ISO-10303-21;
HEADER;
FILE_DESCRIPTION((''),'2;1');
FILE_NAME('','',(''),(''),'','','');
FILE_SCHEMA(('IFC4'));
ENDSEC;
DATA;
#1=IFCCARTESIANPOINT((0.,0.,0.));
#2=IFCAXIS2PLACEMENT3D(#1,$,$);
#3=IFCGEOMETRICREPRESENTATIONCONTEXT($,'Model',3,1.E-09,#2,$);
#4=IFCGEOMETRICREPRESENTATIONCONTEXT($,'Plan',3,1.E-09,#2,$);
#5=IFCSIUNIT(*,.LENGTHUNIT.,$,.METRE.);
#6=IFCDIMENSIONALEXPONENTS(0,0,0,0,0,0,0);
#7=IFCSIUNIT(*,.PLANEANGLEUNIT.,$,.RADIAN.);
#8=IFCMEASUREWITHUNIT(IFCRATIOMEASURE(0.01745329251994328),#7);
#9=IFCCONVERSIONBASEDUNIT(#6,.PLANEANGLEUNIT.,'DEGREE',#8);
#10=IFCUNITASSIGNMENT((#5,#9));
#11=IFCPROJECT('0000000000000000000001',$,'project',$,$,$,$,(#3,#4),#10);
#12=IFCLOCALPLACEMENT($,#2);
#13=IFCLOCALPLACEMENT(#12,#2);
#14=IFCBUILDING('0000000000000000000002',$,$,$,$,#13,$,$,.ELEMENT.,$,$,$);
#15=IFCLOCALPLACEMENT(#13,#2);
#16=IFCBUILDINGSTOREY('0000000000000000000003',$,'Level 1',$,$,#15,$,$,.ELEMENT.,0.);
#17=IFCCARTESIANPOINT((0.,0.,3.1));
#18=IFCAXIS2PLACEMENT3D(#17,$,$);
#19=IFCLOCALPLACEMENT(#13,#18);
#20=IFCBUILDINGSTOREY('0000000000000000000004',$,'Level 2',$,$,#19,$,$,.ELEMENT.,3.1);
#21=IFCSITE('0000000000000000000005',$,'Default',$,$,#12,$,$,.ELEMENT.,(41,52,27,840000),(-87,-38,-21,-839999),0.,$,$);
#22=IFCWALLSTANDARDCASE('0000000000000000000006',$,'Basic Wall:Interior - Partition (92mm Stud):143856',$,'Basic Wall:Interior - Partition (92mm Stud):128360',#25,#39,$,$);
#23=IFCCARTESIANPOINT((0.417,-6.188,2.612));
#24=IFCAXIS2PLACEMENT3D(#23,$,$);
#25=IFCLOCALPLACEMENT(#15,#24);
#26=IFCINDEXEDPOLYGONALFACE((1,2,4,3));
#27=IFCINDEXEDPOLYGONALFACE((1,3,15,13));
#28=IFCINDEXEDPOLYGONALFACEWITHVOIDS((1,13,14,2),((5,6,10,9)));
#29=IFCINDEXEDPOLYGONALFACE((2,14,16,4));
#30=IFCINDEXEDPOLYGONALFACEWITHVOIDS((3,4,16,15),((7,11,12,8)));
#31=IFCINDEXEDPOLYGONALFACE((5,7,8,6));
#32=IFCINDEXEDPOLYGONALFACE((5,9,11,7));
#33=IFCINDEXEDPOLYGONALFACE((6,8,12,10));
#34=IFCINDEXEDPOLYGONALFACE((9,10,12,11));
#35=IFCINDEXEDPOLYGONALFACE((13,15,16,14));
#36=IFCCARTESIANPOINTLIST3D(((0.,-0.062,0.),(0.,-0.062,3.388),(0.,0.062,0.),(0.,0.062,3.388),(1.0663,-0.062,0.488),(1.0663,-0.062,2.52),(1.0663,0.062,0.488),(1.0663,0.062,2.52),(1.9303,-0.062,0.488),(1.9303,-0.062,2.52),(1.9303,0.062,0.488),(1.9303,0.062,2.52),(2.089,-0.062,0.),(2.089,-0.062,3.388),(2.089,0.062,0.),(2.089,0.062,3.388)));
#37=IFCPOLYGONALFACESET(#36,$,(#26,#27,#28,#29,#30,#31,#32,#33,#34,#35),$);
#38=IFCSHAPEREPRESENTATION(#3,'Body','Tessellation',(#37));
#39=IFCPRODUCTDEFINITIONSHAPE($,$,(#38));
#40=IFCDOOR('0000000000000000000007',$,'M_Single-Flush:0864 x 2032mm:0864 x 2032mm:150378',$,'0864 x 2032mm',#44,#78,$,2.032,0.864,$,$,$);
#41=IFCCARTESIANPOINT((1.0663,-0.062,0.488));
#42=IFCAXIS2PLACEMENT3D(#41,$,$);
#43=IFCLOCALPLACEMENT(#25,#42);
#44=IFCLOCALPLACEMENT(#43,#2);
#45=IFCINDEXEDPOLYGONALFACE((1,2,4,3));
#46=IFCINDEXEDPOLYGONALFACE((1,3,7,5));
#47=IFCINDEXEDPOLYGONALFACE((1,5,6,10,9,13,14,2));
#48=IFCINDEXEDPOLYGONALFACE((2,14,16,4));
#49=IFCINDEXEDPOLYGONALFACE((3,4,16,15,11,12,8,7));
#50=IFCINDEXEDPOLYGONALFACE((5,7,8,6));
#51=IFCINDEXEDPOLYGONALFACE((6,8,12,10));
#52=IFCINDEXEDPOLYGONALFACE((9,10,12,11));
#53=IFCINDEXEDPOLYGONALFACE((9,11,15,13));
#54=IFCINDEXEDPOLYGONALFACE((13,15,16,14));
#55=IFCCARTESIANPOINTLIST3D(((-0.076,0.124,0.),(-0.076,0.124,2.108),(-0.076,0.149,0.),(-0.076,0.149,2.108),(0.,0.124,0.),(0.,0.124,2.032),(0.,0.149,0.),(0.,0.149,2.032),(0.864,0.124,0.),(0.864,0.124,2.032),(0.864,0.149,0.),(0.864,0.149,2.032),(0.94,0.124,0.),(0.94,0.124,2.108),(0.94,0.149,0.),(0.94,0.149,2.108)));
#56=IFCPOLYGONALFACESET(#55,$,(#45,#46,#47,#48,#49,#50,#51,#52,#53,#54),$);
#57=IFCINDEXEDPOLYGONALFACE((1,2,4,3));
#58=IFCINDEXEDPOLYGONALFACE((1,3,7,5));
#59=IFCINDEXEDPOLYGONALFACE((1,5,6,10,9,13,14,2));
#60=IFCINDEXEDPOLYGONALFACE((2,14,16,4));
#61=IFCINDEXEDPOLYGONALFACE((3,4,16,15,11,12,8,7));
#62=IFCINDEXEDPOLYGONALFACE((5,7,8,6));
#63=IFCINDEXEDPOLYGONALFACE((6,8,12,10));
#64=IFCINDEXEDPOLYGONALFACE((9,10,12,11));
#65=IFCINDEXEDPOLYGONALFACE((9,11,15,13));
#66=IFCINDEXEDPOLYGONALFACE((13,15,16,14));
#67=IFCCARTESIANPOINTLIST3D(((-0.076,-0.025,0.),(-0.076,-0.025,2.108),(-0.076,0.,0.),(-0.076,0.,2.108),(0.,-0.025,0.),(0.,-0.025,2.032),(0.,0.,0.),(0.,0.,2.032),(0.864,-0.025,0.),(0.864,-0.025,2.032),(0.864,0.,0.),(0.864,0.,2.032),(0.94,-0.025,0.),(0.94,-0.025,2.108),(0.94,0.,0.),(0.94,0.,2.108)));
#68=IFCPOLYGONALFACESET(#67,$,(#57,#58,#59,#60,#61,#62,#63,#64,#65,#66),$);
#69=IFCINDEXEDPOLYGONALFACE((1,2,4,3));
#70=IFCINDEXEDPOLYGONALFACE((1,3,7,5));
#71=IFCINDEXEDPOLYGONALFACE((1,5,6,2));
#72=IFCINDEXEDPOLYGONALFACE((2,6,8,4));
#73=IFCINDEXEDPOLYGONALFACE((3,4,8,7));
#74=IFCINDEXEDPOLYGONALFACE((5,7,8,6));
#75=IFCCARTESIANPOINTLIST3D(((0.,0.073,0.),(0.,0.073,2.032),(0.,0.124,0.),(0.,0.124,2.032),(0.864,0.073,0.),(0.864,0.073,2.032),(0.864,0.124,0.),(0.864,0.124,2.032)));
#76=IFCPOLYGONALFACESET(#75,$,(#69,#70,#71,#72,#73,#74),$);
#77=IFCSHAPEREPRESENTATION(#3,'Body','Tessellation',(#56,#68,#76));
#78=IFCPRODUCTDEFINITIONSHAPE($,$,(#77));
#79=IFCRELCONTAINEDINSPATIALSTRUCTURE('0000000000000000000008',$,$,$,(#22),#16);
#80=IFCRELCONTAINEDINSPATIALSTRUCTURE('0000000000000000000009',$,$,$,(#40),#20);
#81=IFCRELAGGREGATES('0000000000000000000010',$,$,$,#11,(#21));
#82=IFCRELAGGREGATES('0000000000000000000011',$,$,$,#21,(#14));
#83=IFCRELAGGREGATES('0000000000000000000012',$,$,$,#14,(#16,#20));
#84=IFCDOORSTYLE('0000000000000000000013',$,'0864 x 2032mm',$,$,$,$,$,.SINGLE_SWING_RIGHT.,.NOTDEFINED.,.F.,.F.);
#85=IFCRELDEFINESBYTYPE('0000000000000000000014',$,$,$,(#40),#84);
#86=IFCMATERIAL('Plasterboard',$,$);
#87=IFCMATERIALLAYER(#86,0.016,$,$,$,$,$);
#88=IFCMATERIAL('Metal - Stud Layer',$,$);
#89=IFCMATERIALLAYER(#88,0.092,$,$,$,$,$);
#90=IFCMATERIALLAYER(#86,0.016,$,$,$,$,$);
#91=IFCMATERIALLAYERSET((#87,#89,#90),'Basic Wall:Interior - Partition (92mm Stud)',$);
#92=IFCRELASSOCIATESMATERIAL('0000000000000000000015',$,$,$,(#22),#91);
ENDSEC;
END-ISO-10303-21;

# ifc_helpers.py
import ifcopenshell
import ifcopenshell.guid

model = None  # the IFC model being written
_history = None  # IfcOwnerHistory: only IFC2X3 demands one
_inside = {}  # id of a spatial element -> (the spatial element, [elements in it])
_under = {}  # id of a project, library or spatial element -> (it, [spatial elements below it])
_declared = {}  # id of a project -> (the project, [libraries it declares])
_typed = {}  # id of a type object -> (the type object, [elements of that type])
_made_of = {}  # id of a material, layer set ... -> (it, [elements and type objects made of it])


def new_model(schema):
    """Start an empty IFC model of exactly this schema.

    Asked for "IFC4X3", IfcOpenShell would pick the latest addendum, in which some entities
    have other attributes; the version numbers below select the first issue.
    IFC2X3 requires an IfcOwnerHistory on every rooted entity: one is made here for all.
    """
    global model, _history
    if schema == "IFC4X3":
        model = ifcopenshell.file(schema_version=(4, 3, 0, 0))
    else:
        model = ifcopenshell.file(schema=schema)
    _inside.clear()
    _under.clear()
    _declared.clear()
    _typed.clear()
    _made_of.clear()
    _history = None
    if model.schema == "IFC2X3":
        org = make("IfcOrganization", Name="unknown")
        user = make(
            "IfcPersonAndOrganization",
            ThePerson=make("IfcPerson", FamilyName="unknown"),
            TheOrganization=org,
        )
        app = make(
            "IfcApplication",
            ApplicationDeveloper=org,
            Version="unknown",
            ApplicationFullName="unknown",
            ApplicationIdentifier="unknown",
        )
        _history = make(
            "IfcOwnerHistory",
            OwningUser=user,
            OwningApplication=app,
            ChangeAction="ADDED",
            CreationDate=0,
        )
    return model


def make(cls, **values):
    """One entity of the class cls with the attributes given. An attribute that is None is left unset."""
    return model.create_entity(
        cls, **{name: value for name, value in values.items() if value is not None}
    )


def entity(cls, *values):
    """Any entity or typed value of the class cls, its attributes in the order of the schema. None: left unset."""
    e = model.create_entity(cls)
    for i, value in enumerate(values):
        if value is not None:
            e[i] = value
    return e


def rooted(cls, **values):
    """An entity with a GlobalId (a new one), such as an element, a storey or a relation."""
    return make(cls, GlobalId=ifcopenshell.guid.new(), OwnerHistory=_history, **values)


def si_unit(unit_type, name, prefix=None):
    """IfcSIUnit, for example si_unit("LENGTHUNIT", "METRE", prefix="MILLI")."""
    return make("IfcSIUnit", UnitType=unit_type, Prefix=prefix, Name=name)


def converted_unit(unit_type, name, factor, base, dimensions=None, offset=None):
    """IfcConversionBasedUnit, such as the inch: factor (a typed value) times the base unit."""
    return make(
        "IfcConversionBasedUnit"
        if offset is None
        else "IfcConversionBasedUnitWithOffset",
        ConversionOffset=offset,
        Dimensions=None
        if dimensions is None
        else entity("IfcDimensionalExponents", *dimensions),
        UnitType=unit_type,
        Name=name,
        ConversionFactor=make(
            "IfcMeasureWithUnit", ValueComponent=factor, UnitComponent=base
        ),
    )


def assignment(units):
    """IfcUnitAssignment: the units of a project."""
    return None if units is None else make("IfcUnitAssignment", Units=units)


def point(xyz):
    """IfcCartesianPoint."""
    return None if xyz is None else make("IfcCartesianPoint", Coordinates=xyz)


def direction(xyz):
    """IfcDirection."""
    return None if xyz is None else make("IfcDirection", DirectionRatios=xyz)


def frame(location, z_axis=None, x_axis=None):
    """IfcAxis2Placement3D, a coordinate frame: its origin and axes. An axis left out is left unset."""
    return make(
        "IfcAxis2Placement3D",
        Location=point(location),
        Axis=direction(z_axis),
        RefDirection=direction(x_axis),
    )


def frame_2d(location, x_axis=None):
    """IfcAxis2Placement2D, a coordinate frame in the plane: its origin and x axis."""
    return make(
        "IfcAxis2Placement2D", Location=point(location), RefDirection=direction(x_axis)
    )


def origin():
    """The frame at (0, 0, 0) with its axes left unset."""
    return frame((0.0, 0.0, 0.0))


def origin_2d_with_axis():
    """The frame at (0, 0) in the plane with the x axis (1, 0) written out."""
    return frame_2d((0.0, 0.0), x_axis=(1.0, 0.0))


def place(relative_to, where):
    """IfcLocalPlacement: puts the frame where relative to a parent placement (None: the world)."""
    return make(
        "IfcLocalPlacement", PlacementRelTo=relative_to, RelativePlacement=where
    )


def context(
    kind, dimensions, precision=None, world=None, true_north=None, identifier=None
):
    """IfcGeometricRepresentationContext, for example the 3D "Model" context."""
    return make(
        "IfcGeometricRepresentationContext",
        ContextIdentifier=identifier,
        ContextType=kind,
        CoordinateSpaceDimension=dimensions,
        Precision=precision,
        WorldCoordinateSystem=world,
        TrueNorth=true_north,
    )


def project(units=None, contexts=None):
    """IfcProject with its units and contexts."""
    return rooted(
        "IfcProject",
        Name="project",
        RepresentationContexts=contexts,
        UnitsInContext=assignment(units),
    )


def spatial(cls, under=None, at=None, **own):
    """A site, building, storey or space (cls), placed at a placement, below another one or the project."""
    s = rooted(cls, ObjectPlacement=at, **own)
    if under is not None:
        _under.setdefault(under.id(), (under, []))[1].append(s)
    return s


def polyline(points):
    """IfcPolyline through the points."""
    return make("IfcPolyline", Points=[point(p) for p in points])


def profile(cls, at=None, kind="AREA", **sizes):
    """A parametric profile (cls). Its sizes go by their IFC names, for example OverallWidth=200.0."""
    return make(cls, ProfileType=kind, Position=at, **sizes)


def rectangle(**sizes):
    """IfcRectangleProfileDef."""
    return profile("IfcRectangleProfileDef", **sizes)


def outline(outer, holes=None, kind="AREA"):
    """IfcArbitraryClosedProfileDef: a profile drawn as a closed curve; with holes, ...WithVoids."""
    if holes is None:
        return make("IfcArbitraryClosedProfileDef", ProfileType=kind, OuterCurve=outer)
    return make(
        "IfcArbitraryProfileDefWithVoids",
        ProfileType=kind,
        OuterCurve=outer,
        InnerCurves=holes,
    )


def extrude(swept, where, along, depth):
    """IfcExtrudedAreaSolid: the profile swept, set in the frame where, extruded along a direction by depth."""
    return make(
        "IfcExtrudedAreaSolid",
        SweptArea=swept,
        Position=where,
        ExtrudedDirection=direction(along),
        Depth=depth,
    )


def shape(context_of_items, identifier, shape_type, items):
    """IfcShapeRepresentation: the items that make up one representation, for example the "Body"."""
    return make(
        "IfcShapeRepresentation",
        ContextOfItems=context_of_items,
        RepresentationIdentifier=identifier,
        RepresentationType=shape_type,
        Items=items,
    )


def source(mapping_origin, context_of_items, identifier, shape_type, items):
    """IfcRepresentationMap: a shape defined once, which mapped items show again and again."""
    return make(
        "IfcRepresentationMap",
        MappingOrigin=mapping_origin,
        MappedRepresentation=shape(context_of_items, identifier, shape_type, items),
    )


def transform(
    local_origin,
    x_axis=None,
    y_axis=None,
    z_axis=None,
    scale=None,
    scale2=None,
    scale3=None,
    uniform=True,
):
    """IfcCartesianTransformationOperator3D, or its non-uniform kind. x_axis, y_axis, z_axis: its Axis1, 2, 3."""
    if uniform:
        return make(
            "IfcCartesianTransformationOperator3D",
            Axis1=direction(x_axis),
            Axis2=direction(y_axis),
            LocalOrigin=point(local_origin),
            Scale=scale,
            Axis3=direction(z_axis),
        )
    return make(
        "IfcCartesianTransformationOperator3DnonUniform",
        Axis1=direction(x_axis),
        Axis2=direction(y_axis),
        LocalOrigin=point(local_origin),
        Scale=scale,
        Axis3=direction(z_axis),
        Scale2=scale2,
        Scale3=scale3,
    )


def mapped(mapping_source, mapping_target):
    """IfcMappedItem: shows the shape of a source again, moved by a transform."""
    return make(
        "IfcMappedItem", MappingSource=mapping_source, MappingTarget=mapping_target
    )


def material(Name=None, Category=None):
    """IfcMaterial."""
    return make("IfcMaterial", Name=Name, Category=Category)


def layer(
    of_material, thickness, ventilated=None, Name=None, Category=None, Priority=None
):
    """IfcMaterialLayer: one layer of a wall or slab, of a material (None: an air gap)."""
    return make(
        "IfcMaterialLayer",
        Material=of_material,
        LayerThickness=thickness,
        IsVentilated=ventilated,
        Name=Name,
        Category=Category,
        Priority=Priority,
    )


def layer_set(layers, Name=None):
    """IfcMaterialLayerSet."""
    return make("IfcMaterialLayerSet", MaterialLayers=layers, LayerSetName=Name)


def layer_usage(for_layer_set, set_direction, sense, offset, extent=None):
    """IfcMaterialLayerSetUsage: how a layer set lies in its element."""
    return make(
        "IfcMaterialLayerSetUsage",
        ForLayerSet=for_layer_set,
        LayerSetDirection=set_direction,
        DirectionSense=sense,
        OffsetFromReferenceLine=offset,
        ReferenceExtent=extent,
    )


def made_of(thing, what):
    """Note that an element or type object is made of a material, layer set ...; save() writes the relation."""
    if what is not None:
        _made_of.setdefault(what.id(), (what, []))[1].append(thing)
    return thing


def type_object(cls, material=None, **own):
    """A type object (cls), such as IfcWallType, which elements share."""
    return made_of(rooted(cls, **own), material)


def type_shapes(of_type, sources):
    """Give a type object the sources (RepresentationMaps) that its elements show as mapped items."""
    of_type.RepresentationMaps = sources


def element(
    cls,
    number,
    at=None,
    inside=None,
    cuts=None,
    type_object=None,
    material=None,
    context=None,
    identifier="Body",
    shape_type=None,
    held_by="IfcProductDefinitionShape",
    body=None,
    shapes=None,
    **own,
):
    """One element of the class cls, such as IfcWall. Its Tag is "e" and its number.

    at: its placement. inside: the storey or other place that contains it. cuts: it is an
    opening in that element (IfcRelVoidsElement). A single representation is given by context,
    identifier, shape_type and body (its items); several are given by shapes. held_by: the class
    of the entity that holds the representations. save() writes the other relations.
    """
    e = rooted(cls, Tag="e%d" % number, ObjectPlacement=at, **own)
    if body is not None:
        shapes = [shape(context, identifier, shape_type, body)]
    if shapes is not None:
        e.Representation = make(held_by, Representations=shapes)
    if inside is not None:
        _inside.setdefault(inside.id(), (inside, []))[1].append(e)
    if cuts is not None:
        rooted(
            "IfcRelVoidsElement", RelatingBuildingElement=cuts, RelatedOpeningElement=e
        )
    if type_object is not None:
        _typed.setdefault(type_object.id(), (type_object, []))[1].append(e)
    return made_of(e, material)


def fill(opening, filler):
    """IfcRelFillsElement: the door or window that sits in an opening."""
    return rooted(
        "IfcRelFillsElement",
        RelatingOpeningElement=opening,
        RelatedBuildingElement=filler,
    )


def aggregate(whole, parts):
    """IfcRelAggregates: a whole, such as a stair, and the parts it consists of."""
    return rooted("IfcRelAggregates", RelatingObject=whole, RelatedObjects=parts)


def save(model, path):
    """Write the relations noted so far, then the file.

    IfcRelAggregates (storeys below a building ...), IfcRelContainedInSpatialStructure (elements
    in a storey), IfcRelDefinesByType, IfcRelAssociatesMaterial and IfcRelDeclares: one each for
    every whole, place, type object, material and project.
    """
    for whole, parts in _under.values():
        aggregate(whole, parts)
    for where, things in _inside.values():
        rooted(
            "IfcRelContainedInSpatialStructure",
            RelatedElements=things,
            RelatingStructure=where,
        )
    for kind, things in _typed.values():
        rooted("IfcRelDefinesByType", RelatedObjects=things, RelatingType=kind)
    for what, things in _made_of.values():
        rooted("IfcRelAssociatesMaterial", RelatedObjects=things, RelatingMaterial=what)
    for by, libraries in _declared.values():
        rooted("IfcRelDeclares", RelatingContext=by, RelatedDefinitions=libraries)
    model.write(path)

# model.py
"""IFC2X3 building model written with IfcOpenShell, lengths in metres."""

from ifc_helpers import new_model, entity, si_unit, converted_unit, frame, frame_2d, origin, origin_2d_with_axis, place, context, project, spatial, polyline, rectangle, outline, extrude, source, transform, mapped, material, layer, layer_set, layer_usage, type_object, type_shapes, element, fill, save


model = new_model("IFC2X3")

# Units and contexts
model_context = context("Model", 3, precision=1e-09, world=origin())
plan_context = context("Plan", 3, precision=1e-09, world=origin())
ifc_project = project(units=[si_unit("LENGTHUNIT", "METRE"), converted_unit("PLANEANGLEUNIT", "DEGREE", entity("IfcRatioMeasure", 0.01745329251994328), si_unit("PLANEANGLEUNIT", "RADIAN"), dimensions=[0, 0, 0, 0, 0, 0, 0])], contexts=[model_context, plan_context])

# Site, building, storey
site_placement = place(None, origin())
site = spatial("IfcSite", under=ifc_project, at=site_placement, Name="Default", CompositionType="ELEMENT", RefLatitude=(41, 52, 27, 840000), RefLongitude=(-87, -38, -21, -839999), RefElevation=0.0)
building_placement = place(site_placement, origin())
building = spatial("IfcBuilding", under=site, at=building_placement, CompositionType="ELEMENT")
storey_1_placement = place(building_placement, origin())
storey_1 = spatial("IfcBuildingStorey", under=building, at=storey_1_placement, Name="Level 1", CompositionType="ELEMENT", Elevation=0.0)

# Shared definitions
ifc_material_1 = material(Name="Metal - Stud Layer")
ifc_material_2 = material(Name="Plasterboard")

# Shared definitions
ifc_layer_1 = layer(ifc_material_2, 0.016)
ifc_layer_2 = layer(ifc_material_1, 0.092)
ifc_layer_3 = layer(ifc_material_2, 0.016)
ifc_layer_set_1 = layer_set([ifc_layer_1, ifc_layer_2, ifc_layer_3], Name="Basic Wall:Interior - Partition (92mm Stud)")

# Wall, opening
ifc_layer_usage_1 = layer_usage(ifc_layer_set_1, "AXIS2", "NEGATIVE", 0.062)
wall_1_placement = place(storey_1_placement, frame((0.417, -6.188, 2.612)))
wall_1 = element("IfcWallStandardCase", 1, at=wall_1_placement, inside=storey_1, material=ifc_layer_usage_1, Name="Basic Wall:Interior - Partition (92mm Stud):143856", ObjectType="Basic Wall:Interior - Partition (92mm Stud):128360", context=model_context, shape_type="SweptSolid", body=[
    extrude(rectangle(XDim=2.089, YDim=0.124, at=frame_2d((1.0445, 0.0), x_axis=(-1.0, 0.0))), origin(), (0.0, 0.0, 1.0), 3.388),
])
opening_1_placement = place(wall_1_placement, frame((1.0663, -0.062, 0.488)))
opening_1 = element("IfcOpeningElement", 2, at=opening_1_placement, cuts=wall_1, ObjectType="Opening", context=model_context, shape_type="SweptSolid", body=[
    extrude(rectangle(XDim=0.864, YDim=2.032, at=frame_2d((1.016, 0.432), x_axis=(0.0, 1.0))), frame((0.0, 0.0, 0.0), z_axis=(0.0, 1.0, 0.0), x_axis=(0.0, 0.0, 1.0)), (0.0, 0.0, 1.0), 0.124),
])

# Shared definitions
storey_2_placement = place(building_placement, frame((0.0, 0.0, 3.1)))
storey_2 = spatial("IfcBuildingStorey", under=building, at=storey_2_placement, Name="Level 2", CompositionType="ELEMENT", Elevation=3.1)

# Door
door_style_1 = type_object("IfcDoorStyle", Name="0864 x 2032mm", ConstructionType="NOTDEFINED", OperationType="SINGLE_SWING_RIGHT", ParameterTakesPrecedence=False, Sizeable=False)
shared_shape_1 = source(origin(), model_context, "Body", "SweptSolid", [
    extrude(outline(polyline([(-0.508, -1.073), (0.508, -1.073), (0.508, 1.035), (0.432, 1.035), (0.432, -0.997), (-0.432, -0.997), (-0.432, 1.035), (-0.508, 1.035), (-0.508, -1.073)])), frame((0.432, 0.124, 1.035), z_axis=(0.0, 1.0, 0.0), x_axis=(1.0, 0.0, 0.0)), (0.0, 0.0, 1.0), 0.025),
    extrude(outline(polyline([(-1.073, -0.508), (1.035, -0.508), (1.035, -0.432), (-0.997, -0.432), (-0.997, 0.432), (1.035, 0.432), (1.035, 0.508), (-1.073, 0.508), (-1.073, -0.508)])), frame((0.432, -0.025, 1.035), z_axis=(0.0, 1.0, 0.0), x_axis=(0.0, 0.0, -1.0)), (0.0, 0.0, 1.0), 0.025),
    extrude(rectangle(XDim=0.051, YDim=0.864, at=origin_2d_with_axis()), frame((0.432, 0.0985, 0.0), z_axis=(0.0, 0.0, 1.0), x_axis=(0.0, 1.0, 0.0)), (0.0, 0.0, 1.0), 2.032),
])
type_shapes(door_style_1, [shared_shape_1])
door_1_placement = place(opening_1_placement, origin())
door_1 = element("IfcDoor", 3, at=door_1_placement, inside=storey_2, type_object=door_style_1, Name="M_Single-Flush:0864 x 2032mm:0864 x 2032mm:150378", ObjectType="0864 x 2032mm", OverallHeight=2.032, OverallWidth=0.864, context=model_context, shape_type="MappedRepresentation", body=[
    mapped(shared_shape_1, transform((0.0, 0.0, 0.0), scale=1.0)),
])
fill(opening_1, door_1)

save(model, "model.ifc")
